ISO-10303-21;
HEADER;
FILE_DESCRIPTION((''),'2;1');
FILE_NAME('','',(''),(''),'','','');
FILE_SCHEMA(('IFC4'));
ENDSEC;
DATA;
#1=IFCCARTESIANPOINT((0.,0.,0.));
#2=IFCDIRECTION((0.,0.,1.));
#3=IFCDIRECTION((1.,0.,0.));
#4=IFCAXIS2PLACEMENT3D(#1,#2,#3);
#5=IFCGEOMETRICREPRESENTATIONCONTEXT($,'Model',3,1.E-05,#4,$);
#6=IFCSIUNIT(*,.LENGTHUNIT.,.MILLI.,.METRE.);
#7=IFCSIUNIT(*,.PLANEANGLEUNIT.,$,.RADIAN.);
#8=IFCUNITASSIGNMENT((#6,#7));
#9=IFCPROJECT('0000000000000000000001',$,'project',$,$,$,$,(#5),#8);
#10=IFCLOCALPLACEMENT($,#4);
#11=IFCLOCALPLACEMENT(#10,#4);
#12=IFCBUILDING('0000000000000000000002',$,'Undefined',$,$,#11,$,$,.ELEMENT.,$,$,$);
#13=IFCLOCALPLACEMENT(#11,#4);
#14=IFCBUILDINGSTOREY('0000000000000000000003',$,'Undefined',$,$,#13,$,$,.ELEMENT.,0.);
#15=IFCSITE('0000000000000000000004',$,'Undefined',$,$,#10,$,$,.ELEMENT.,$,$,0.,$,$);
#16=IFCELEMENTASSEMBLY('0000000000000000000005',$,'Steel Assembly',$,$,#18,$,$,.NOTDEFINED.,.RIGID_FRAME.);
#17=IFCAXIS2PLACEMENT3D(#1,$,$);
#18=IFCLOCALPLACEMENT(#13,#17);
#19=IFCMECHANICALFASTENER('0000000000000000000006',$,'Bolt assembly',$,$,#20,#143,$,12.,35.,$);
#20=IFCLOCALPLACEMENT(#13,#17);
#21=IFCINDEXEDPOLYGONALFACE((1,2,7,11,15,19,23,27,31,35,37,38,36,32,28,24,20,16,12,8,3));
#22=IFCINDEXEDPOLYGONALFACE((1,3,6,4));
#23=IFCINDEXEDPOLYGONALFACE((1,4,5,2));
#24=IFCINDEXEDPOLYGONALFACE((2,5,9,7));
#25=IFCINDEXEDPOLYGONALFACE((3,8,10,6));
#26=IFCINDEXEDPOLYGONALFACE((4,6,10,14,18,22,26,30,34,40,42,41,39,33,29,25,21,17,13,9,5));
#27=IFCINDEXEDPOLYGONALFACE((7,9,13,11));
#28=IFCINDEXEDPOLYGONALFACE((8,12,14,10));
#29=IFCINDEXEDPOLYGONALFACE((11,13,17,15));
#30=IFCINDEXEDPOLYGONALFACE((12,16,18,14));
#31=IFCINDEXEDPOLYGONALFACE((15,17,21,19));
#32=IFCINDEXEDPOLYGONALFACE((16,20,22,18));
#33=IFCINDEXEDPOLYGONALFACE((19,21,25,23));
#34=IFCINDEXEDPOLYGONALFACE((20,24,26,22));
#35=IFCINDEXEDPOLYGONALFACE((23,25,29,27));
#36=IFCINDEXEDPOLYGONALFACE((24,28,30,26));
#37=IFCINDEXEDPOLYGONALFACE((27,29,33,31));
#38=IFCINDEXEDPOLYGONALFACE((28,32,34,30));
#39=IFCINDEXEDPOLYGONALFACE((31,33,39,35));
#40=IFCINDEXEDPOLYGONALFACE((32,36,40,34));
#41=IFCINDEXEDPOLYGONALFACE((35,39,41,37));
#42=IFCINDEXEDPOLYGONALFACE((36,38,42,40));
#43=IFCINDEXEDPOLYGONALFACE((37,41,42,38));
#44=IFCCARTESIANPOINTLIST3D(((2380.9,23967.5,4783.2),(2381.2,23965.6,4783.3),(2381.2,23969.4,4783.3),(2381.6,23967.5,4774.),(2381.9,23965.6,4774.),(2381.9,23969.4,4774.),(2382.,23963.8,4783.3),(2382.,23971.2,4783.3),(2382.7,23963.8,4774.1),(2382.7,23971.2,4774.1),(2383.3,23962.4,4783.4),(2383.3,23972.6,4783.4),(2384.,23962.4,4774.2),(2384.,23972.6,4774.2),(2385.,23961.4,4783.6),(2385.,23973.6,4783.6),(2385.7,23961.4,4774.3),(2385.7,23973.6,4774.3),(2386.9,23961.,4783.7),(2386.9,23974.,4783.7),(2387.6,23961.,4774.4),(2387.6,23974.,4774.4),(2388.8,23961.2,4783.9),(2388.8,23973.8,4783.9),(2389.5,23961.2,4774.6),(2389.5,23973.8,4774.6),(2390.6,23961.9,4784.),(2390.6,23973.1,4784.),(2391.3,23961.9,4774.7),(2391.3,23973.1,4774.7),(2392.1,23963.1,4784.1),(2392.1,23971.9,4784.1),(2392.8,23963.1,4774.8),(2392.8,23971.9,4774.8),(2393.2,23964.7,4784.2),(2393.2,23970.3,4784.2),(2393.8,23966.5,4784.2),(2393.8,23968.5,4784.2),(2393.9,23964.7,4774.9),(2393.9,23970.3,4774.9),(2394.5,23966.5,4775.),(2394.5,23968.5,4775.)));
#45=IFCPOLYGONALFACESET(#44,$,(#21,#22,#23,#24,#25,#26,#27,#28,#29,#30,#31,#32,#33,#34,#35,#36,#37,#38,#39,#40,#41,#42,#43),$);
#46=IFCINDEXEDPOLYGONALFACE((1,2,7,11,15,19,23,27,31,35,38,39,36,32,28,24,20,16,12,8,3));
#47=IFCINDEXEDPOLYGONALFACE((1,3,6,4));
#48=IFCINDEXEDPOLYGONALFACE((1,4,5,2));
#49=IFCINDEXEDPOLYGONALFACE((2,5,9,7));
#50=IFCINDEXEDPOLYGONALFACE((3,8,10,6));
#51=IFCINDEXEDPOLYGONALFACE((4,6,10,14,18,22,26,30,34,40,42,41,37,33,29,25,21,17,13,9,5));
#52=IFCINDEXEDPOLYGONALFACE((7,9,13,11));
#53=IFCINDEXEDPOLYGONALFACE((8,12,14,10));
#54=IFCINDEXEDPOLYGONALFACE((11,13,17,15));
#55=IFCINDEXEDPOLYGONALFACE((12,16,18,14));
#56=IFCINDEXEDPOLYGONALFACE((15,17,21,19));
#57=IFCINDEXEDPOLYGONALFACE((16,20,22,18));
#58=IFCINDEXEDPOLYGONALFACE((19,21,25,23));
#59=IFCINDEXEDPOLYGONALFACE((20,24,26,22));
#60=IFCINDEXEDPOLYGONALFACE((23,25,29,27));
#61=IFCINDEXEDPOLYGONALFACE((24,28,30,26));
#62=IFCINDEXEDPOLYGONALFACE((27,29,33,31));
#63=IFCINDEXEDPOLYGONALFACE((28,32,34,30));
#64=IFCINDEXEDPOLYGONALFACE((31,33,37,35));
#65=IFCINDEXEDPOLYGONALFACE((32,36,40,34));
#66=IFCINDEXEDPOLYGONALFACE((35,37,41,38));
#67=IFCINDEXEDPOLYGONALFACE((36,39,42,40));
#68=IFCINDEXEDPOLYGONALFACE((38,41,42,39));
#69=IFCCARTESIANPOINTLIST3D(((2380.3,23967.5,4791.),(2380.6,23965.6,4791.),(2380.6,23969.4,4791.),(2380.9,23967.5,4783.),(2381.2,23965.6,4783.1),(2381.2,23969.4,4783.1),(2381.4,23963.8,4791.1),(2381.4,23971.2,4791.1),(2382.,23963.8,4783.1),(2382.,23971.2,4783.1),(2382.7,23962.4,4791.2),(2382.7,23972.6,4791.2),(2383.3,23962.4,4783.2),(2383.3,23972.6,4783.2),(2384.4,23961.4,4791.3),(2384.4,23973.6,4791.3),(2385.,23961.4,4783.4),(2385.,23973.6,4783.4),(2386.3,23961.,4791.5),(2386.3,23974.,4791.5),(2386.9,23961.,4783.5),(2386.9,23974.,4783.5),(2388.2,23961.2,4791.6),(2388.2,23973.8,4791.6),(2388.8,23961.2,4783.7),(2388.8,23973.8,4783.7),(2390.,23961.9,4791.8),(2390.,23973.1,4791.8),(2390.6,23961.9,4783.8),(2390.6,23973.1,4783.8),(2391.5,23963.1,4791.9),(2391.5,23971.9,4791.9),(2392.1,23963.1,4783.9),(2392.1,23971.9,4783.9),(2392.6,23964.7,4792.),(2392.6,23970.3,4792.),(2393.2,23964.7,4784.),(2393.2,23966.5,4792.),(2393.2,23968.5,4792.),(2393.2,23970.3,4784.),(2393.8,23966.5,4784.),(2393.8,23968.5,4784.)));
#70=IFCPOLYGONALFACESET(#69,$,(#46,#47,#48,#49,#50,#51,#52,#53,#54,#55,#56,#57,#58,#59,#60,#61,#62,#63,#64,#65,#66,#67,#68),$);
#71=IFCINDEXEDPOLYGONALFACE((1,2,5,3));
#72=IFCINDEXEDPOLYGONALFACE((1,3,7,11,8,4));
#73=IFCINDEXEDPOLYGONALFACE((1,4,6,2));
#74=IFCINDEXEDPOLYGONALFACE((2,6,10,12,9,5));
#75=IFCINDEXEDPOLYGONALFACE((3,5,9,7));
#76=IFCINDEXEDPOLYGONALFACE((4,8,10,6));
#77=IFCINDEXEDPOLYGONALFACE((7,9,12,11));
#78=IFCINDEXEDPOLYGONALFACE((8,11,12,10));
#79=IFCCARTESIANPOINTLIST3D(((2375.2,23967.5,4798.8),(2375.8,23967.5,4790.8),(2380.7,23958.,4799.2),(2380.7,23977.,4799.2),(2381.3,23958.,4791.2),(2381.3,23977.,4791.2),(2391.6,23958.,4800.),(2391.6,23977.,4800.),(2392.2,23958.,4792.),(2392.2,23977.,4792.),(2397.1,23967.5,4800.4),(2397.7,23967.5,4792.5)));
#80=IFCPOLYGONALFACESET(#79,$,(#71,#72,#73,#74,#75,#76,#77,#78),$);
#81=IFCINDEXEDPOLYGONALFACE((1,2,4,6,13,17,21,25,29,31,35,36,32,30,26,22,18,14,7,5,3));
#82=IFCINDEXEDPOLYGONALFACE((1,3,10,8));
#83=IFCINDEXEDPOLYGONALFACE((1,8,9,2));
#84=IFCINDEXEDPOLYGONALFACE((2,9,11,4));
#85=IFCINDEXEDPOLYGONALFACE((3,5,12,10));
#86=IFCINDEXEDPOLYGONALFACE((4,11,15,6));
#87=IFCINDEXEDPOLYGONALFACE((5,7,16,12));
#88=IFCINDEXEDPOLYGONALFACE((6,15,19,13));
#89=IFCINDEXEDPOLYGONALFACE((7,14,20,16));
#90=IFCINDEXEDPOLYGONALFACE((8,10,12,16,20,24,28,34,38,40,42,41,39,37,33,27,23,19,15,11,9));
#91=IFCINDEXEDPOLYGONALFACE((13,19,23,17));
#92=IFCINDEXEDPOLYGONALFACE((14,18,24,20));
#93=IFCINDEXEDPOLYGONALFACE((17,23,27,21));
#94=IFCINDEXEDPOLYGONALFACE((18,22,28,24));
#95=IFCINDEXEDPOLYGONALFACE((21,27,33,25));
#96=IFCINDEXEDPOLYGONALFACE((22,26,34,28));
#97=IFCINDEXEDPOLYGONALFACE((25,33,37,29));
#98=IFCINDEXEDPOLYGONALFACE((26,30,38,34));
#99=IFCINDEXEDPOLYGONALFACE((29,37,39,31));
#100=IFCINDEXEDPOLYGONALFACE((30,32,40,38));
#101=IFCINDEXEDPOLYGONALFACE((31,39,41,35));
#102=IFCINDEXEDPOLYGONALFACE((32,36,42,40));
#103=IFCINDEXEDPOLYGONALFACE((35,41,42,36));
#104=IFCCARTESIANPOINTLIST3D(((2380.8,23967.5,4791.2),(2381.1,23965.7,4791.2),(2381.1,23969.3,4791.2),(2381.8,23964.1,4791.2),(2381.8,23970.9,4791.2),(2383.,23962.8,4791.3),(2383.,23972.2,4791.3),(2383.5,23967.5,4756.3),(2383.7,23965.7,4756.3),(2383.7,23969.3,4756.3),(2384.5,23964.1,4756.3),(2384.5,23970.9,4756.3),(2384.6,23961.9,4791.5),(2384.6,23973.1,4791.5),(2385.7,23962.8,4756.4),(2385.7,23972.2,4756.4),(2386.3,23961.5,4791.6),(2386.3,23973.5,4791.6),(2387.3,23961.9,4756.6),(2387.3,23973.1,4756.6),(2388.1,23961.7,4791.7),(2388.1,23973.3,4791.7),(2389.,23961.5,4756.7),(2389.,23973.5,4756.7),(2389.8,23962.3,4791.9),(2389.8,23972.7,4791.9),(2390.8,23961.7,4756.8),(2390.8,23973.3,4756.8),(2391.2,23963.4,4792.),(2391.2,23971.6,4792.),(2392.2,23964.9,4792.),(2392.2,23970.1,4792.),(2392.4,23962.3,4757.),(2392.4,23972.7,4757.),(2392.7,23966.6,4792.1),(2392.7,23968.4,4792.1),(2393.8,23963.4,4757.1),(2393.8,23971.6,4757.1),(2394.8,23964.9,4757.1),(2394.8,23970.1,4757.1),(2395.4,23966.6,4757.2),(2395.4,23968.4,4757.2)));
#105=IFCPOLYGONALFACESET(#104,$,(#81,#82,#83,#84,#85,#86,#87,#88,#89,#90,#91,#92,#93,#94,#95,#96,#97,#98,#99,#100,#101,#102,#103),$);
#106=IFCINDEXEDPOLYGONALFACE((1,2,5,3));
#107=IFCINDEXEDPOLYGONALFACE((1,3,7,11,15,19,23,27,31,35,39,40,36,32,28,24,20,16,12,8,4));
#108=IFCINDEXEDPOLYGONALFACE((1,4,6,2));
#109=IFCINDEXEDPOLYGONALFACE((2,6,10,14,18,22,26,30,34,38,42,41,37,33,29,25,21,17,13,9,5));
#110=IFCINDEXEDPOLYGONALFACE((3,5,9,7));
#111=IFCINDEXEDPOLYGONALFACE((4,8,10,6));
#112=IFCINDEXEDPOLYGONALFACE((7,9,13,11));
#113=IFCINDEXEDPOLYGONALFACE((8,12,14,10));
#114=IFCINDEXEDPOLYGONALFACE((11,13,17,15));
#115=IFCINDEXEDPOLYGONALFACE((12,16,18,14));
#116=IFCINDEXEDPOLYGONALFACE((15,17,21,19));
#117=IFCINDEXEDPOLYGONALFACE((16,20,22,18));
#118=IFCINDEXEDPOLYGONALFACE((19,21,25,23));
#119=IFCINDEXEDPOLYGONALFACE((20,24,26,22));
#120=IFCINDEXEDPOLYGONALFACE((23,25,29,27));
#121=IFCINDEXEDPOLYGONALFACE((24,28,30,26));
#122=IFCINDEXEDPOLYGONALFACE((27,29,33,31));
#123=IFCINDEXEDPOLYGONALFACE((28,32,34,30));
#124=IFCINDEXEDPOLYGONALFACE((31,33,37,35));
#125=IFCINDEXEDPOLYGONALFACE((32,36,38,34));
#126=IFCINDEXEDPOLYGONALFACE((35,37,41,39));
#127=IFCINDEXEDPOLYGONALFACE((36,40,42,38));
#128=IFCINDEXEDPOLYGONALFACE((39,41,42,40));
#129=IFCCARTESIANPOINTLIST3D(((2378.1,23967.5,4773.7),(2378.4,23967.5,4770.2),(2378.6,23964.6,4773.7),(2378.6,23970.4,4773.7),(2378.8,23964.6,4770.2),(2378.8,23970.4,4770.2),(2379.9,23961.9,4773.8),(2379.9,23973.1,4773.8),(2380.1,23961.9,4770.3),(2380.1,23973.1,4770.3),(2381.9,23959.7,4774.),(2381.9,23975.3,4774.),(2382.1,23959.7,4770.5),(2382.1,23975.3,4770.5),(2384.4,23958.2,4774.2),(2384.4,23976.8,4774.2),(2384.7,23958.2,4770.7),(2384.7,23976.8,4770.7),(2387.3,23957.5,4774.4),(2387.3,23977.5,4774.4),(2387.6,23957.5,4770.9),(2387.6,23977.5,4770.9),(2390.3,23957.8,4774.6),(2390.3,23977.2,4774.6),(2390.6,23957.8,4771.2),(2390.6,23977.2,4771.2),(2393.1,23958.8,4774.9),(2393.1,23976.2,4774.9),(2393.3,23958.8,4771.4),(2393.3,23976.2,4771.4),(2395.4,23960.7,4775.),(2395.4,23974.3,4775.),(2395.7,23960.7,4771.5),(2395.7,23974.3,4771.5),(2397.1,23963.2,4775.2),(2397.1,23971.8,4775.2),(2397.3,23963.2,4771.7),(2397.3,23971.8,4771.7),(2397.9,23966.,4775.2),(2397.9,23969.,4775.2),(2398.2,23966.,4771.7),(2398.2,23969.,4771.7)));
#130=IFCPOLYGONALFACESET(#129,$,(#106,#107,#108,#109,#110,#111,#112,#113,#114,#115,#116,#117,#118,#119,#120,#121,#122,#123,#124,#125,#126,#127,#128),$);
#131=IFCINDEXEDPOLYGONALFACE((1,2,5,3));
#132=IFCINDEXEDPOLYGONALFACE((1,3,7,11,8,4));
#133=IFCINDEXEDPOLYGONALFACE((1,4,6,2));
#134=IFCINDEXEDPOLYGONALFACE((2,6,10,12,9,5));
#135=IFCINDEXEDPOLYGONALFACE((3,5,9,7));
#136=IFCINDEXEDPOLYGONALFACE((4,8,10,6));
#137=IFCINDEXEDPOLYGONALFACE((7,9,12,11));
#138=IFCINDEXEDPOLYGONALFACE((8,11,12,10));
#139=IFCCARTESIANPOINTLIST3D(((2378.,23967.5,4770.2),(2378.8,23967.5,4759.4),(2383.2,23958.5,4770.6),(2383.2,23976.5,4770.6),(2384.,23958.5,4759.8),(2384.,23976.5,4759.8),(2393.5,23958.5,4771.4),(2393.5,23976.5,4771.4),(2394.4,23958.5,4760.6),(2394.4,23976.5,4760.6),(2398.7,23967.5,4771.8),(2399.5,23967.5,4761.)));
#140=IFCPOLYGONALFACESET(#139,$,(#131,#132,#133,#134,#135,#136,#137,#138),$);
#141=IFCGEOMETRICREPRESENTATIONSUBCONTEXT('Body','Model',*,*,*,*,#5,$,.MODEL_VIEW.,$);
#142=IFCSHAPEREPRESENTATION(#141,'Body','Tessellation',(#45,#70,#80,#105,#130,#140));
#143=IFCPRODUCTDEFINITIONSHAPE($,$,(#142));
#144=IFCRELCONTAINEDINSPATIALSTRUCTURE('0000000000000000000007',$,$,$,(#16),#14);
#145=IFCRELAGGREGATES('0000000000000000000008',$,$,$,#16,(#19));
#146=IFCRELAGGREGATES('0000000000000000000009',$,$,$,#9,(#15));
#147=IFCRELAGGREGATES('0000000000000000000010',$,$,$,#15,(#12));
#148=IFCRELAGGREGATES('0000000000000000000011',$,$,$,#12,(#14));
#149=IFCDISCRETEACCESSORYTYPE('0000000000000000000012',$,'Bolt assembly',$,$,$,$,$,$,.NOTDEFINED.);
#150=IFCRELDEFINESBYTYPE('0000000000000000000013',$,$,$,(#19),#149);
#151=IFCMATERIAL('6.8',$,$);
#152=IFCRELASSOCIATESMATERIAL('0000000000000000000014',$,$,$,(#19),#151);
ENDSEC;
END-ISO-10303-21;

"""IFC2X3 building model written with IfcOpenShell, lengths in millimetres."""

from ifc_helpers import new_model, si_unit, frame, origin_with_axes, origin_2d_with_axis, place, context, subcontext, project, spatial, polyline, circle, outline, extrude, source, transform, mapped, material, type_object, element, aggregate, save


model = new_model("IFC2X3")

# Units and contexts
model_context = context("Model", 3, precision=1e-05, world=origin_with_axes())
body_context = subcontext(model_context, "Body", "Model", "MODEL_VIEW")
ifc_project = project(units=[si_unit("LENGTHUNIT", "METRE", prefix="MILLI"), si_unit("PLANEANGLEUNIT", "RADIAN")], contexts=[model_context])

# Site, building, storey
site_placement = place(None, origin_with_axes())
site = spatial("IfcSite", under=ifc_project, at=site_placement, Name="Undefined", CompositionType="ELEMENT", RefElevation=0.0)
building_placement = place(site_placement, origin_with_axes())
building = spatial("IfcBuilding", under=site, at=building_placement, Name="Undefined", CompositionType="ELEMENT")
storey_placement = place(building_placement, origin_with_axes())
storey = spatial("IfcBuildingStorey", under=building, at=storey_placement, Name="Undefined", CompositionType="ELEMENT", Elevation=0.0)

# Shared definitions
ifc_material_1 = material(Name="6.8")
discrete_accessory_type_1 = type_object("IfcDiscreteAccessoryType", Name="Bolt assembly")

# Element assembly, mechanical fastener
shared_shape_1 = source(origin_with_axes(), body_context, "Body", "SweptSolid", [
    extrude(circle(Radius=6.5, at=origin_2d_with_axis()), frame((0.0, -0.1, 0.0), z_axis=(0.0, 1.0, 0.0), x_axis=(1.0, 0.0, 0.0)), (0.0, 0.0, 1.0), 9.3),
    extrude(circle(Radius=6.5, at=origin_2d_with_axis()), frame((0.0, -7.9, 0.0), z_axis=(0.0, 1.0, 0.0), x_axis=(1.0, 0.0, 0.0)), (0.0, 0.0, 1.0), 8.0),
    extrude(outline(polyline([(11.0, 0.0), (5.5, 9.5), (-5.5, 9.5), (-11.0, 0.0), (-5.5, -9.5), (5.5, -9.5), (11.0, 0.0)])), frame((0.0, -16.0, 0.0), z_axis=(0.0, 1.0, 0.0), x_axis=(1.0, 0.0, 0.0)), (0.0, 0.0, 1.0), 8.0),
    extrude(circle(Radius=6.0, at=origin_2d_with_axis()), frame((0.0, -8.0, 0.0), z_axis=(0.0, 1.0, 0.0), x_axis=(1.0, 0.0, 0.0)), (0.0, 0.0, 1.0), 35.0),
    extrude(circle(Radius=10.0, at=origin_2d_with_axis()), frame((0.0, 9.2, 0.0), z_axis=(0.0, 1.0, 0.0), x_axis=(1.0, 0.0, 0.0)), (0.0, 0.0, 1.0), 3.5),
    extrude(outline(polyline([(10.4, 0.0), (5.2, 9.0), (-5.2, 9.0), (-10.4, 0.0), (-5.2, -9.0), (5.2, -9.0), (10.4, 0.0)])), frame((0.0, 12.7, 0.0), z_axis=(0.0, 1.0, 0.0), x_axis=(1.0, 0.0, 0.0)), (0.0, 0.0, 1.0), 10.8),
])
assembly_1_placement = place(storey_placement, origin_with_axes())
assembly_1 = element("IfcElementAssembly", 1, at=assembly_1_placement, inside=storey, Name="Steel Assembly", AssemblyPlace="NOTDEFINED", PredefinedType="RIGID_FRAME")
mechanical_fastener_1_placement = place(assembly_1_placement, frame((2387.4, 23967.5, 4783.6), z_axis=(0.0, -1.0, 0.0), x_axis=(-0.997054, 0.0, -0.076696)))
mechanical_fastener_1 = element("IfcMechanicalFastener", 2, at=mechanical_fastener_1_placement, type_object=discrete_accessory_type_1, material=ifc_material_1, Name="Bolt assembly", NominalDiameter=12.0, NominalLength=35.0, context=body_context, shape_type="MappedRepresentation", body=[
    mapped(shared_shape_1, transform((0.0, 0.0, 0.0))),
])
aggregate(assembly_1, [mechanical_fastener_1])

save(model, "model.ifc")
